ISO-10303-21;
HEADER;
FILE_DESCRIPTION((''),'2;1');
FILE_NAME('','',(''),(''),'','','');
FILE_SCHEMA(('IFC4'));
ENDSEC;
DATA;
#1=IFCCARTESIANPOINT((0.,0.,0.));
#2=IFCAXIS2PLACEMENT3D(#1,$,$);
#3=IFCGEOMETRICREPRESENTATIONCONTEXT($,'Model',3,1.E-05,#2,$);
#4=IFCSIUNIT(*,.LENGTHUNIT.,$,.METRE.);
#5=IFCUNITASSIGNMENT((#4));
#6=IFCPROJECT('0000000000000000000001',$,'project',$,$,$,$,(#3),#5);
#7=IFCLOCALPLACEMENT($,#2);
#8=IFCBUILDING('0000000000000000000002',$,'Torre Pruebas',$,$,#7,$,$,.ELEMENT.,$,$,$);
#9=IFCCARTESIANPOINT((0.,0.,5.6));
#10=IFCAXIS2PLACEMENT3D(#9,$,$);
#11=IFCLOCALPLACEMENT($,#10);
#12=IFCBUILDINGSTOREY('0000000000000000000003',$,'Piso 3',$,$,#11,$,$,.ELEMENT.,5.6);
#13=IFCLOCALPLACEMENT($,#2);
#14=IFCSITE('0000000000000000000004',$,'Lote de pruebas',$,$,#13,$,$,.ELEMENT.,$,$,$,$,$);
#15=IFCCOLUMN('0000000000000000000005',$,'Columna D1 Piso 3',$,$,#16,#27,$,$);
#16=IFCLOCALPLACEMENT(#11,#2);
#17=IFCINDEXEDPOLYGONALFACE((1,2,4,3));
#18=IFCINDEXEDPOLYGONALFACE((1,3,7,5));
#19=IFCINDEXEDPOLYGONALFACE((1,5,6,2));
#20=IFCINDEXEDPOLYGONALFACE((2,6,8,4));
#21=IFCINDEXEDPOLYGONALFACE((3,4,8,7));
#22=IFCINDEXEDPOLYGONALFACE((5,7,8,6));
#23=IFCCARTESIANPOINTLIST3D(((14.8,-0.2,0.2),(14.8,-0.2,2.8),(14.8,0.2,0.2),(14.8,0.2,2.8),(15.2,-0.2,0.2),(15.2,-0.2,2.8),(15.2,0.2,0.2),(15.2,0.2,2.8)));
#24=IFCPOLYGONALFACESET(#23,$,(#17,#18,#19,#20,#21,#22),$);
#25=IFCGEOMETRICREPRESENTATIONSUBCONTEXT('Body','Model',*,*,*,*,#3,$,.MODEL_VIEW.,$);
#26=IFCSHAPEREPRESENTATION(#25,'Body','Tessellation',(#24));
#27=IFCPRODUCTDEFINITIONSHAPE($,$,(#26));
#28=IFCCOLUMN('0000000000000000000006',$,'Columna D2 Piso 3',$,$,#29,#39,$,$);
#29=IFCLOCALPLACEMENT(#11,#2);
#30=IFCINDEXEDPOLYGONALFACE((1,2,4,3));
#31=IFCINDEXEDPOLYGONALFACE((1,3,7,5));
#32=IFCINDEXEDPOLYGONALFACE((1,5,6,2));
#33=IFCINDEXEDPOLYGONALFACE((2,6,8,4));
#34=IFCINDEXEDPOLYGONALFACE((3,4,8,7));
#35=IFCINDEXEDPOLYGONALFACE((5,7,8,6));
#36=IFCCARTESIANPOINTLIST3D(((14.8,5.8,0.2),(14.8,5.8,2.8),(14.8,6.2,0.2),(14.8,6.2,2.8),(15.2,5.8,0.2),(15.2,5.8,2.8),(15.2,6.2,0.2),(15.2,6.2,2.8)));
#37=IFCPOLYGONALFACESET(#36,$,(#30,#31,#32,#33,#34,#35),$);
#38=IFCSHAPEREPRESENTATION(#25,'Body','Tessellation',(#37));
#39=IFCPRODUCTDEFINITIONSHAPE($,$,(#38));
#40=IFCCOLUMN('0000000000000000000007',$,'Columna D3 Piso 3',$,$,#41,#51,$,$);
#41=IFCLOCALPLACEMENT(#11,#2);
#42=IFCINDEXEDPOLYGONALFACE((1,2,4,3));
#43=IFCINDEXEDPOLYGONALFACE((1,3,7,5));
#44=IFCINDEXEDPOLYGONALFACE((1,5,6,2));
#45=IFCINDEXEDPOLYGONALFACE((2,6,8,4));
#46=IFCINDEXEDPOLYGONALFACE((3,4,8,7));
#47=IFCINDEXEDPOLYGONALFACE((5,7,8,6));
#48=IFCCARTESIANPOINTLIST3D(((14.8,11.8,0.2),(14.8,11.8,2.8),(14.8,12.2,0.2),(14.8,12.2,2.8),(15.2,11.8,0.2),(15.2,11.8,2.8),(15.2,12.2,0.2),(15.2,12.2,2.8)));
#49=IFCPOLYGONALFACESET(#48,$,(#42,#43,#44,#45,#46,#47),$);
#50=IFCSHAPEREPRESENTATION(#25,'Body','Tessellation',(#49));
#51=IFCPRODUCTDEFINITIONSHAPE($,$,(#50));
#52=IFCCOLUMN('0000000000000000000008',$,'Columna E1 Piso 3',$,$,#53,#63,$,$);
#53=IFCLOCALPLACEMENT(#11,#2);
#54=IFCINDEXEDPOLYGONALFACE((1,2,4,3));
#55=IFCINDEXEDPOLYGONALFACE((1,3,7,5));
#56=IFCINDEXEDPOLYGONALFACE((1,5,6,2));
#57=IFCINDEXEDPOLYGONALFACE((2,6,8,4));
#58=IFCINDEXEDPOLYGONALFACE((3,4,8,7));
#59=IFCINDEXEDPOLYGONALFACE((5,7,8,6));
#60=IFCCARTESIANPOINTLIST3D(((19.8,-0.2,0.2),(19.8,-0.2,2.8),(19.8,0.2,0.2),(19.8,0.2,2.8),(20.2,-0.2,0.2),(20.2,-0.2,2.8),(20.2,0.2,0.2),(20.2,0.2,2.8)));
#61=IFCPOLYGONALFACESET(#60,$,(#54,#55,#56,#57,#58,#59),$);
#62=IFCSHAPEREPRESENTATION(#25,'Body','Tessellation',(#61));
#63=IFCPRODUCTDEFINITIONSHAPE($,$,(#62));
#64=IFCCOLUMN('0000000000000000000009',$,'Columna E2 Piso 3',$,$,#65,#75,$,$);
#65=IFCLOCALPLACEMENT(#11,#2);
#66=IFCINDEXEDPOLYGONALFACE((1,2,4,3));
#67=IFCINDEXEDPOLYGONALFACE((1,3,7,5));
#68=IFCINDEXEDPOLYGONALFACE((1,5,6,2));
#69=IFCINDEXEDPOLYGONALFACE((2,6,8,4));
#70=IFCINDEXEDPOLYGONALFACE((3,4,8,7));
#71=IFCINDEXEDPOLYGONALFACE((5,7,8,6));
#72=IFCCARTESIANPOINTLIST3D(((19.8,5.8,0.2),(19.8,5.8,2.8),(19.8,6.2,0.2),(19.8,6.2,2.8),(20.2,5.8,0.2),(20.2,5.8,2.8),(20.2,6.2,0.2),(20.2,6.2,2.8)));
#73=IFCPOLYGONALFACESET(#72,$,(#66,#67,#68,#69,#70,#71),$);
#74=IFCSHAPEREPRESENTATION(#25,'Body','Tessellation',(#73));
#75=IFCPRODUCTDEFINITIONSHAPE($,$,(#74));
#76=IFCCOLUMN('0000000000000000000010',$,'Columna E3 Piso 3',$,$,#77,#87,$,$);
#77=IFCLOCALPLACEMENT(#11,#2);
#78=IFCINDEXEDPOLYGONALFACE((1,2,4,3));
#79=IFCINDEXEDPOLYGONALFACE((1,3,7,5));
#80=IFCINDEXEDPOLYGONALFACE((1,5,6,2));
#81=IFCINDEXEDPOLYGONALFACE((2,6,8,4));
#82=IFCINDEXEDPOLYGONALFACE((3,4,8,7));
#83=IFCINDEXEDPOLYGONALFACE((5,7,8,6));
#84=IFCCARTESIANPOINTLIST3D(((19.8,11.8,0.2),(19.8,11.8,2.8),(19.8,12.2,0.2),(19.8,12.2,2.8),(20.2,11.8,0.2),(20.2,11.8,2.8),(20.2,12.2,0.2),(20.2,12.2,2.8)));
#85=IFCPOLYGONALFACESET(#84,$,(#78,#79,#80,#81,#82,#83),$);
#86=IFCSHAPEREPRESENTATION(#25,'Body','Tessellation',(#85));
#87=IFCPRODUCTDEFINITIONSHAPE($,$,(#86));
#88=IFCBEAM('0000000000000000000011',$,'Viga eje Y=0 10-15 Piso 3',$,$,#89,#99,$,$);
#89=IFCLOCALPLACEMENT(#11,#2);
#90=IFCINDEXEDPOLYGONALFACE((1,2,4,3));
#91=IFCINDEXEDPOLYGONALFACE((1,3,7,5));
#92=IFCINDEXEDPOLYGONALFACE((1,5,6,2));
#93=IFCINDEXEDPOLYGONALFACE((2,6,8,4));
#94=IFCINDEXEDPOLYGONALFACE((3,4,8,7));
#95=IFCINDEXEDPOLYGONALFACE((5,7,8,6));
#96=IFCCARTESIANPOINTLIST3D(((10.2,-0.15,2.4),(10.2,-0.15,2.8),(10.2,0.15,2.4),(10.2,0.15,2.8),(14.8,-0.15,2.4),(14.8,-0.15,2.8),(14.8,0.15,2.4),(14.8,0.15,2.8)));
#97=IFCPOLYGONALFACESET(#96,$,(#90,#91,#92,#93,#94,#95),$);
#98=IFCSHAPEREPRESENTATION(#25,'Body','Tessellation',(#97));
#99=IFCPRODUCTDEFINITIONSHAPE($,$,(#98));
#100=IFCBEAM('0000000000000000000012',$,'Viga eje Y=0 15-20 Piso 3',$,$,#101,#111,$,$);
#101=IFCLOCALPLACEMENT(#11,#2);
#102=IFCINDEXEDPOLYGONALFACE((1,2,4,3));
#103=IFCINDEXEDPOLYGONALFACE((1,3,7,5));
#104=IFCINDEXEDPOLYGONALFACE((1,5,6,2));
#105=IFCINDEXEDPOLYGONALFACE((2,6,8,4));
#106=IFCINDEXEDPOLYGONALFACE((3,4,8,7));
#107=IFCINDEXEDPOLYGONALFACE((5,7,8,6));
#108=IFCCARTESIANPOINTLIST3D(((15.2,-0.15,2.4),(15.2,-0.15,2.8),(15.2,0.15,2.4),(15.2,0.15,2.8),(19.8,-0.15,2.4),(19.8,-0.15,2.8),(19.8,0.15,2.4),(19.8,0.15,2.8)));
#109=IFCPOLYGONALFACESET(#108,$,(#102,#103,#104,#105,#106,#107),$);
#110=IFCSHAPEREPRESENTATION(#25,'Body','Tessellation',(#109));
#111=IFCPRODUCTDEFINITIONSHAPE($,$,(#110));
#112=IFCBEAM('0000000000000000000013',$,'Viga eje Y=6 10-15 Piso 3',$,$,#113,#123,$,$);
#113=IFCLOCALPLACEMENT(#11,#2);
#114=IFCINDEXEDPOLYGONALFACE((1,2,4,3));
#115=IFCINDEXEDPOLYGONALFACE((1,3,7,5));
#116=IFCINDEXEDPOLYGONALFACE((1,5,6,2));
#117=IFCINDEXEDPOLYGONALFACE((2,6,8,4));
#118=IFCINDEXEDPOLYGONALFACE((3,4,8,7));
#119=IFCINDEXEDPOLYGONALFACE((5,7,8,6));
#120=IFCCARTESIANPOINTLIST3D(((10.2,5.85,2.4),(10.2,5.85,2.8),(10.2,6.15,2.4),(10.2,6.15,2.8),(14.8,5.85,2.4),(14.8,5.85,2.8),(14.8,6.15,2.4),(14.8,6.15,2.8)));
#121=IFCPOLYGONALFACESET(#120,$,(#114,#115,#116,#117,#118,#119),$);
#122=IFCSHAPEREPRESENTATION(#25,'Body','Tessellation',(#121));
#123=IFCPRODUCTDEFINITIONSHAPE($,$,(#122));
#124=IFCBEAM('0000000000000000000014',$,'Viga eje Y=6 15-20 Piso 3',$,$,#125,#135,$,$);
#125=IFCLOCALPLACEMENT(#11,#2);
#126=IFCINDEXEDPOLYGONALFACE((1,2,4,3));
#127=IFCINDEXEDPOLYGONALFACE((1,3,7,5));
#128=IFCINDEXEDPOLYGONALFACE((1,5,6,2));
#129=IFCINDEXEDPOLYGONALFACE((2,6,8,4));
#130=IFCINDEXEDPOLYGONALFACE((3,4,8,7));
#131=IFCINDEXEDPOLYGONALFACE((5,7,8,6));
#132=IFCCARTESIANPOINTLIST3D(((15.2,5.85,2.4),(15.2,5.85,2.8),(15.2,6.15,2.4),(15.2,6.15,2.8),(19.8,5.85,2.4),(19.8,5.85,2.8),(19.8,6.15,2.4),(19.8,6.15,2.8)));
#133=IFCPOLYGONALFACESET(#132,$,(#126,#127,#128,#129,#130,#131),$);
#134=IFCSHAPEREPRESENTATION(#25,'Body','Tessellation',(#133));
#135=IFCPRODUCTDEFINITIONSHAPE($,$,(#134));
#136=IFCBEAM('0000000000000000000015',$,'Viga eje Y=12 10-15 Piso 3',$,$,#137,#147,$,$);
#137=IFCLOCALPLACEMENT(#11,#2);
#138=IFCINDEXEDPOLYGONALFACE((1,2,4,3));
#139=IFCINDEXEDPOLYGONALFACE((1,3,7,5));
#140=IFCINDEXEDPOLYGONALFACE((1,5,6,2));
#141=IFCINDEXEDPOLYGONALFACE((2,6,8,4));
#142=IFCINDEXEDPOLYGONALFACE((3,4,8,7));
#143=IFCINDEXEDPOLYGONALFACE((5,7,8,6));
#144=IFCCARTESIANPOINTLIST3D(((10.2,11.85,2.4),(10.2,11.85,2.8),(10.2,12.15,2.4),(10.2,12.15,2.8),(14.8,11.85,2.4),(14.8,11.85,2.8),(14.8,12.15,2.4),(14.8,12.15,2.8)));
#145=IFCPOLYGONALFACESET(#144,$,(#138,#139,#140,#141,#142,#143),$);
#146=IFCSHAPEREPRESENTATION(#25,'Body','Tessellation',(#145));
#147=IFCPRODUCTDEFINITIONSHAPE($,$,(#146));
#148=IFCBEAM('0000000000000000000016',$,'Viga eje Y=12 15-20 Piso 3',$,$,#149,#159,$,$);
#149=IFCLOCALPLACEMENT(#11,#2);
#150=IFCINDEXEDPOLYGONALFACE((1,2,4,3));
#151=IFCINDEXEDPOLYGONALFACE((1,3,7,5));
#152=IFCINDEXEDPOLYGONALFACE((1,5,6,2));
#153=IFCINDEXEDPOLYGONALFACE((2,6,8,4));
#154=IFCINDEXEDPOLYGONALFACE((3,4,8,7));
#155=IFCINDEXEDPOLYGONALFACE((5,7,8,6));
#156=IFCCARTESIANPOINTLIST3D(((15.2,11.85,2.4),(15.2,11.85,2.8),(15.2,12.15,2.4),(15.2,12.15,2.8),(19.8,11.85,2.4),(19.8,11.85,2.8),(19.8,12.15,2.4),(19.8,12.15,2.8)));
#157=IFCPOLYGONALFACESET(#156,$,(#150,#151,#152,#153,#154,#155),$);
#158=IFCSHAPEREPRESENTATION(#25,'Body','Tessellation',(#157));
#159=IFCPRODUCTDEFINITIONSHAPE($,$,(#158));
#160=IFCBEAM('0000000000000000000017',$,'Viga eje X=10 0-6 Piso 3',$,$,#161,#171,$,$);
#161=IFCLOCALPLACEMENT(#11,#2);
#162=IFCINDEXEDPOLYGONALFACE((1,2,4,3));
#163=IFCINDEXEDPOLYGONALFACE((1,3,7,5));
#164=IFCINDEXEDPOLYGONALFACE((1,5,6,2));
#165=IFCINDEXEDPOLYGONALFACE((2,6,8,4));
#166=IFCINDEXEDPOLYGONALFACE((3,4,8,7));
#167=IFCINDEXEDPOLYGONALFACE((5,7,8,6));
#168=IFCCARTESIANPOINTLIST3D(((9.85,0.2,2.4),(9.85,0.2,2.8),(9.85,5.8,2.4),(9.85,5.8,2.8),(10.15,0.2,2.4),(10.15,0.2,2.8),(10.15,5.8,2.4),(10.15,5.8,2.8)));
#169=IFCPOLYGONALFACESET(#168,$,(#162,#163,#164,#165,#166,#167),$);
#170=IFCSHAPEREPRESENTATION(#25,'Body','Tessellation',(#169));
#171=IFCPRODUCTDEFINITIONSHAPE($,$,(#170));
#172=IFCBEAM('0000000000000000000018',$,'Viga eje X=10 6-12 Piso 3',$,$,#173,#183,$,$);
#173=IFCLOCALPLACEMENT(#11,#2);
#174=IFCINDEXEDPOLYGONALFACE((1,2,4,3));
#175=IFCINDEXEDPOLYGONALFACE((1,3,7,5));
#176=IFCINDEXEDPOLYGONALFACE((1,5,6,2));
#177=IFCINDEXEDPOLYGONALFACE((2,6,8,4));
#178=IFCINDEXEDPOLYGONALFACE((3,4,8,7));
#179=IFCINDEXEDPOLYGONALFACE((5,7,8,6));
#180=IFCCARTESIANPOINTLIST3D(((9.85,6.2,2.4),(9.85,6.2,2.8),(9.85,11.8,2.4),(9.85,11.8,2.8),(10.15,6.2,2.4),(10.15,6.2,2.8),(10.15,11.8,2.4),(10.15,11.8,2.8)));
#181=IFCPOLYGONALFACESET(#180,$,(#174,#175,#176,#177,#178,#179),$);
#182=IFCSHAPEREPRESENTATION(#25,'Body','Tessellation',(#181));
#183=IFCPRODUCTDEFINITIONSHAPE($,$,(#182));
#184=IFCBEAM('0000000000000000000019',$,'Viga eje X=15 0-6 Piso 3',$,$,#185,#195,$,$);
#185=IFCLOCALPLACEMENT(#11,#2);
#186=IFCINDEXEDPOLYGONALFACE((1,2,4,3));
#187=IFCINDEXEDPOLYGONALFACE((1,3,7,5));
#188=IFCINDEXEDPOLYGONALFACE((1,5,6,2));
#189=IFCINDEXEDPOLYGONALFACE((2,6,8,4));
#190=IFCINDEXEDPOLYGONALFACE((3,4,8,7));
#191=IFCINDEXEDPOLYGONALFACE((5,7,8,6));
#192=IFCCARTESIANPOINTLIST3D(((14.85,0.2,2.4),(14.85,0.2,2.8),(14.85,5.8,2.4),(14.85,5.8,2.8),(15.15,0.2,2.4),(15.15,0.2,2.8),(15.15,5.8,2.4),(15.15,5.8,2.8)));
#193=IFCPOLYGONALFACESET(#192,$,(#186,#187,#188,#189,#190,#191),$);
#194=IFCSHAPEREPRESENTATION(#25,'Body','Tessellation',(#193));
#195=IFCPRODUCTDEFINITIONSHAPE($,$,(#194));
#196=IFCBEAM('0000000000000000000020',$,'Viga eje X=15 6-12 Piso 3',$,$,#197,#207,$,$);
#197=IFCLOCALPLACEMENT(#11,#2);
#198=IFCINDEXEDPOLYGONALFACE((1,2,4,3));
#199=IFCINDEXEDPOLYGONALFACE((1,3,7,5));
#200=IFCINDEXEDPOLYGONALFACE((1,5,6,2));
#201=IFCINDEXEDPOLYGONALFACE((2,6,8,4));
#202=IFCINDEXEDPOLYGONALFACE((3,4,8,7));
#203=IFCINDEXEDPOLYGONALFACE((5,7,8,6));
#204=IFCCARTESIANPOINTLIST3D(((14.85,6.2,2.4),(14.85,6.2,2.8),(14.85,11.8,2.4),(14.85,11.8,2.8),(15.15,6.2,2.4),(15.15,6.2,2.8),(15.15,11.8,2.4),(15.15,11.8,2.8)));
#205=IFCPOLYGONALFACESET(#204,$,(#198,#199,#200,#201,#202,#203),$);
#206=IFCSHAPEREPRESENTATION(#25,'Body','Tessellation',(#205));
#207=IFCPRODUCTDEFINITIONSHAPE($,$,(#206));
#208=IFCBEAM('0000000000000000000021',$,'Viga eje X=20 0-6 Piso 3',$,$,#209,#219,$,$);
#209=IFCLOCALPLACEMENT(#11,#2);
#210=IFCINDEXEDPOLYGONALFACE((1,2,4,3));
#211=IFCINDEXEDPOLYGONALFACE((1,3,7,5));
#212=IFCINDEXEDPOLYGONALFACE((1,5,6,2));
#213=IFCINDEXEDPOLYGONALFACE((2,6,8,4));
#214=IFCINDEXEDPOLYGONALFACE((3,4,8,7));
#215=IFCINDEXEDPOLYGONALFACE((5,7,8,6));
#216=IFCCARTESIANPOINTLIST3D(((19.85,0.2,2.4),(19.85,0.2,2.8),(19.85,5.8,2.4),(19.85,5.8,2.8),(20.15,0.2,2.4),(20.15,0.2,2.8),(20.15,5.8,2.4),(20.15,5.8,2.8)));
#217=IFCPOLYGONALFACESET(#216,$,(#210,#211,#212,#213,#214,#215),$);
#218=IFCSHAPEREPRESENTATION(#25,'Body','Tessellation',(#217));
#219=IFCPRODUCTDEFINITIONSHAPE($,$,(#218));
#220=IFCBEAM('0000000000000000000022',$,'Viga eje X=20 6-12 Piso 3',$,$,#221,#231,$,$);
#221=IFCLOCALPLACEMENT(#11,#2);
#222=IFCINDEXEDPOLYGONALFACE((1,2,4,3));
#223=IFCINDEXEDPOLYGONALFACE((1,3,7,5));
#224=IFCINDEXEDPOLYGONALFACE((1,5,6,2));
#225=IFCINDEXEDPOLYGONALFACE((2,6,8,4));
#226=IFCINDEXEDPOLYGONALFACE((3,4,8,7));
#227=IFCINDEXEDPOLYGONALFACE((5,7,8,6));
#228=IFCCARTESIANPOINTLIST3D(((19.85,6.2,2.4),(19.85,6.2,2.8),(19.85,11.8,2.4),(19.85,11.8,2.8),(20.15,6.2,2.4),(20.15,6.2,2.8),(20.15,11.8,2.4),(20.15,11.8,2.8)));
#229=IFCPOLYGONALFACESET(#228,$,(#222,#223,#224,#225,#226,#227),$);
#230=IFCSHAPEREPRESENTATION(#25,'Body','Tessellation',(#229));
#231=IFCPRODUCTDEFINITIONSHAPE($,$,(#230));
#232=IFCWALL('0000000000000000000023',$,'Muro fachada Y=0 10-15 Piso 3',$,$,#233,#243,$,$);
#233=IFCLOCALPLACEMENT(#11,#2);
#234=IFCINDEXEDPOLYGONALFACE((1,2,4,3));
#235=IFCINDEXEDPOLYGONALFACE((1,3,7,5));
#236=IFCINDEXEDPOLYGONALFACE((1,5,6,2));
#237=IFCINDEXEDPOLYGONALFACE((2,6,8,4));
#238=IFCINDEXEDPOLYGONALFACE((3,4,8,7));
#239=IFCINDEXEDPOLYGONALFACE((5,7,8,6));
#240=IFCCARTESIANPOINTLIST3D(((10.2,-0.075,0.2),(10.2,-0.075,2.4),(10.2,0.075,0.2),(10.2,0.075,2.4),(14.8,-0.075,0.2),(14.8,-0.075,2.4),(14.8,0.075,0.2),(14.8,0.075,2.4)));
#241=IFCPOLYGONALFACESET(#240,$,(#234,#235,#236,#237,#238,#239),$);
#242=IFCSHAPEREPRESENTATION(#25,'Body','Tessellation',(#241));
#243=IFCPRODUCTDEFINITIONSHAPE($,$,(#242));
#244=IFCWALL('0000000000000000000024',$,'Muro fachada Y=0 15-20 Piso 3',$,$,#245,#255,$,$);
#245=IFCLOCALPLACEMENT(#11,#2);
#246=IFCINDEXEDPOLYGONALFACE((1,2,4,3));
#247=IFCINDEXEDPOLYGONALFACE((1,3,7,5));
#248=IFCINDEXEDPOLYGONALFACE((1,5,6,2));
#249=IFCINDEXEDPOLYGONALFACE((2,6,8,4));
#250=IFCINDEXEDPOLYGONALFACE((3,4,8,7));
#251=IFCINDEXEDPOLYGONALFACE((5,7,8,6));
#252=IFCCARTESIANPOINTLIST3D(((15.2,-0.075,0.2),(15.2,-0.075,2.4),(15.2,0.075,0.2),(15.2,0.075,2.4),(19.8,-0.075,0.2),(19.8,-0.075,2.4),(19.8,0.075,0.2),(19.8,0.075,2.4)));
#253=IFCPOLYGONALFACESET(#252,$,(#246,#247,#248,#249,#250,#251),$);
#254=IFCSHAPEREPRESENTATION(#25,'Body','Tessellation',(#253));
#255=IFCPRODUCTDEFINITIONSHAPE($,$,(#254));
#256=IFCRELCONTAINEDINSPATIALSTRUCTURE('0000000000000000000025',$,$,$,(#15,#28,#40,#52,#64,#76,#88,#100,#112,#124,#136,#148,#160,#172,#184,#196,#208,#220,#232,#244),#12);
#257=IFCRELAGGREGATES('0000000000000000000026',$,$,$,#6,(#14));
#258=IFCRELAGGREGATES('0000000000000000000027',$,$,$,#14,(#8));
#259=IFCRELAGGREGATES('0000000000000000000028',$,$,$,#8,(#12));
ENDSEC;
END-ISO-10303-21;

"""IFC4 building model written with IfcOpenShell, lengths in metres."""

from ifc_helpers import new_model, si_unit, frame, origin, origin_2d, place, context, subcontext, project, spatial, rectangle, extrude, element, save


model = new_model("IFC4")

# Units and contexts
model_context = context("Model", 3, precision=1e-05, world=origin())
body_context = subcontext(model_context, "Body", "Model", "MODEL_VIEW")
ifc_project = project(units=[si_unit("LENGTHUNIT", "METRE")], contexts=[model_context])

# Site, building, storey
site_placement = place(None, origin())
site = spatial("IfcSite", under=ifc_project, at=site_placement, Name="Lote de pruebas", CompositionType="ELEMENT")
building_placement = place(None, origin())
building = spatial("IfcBuilding", under=site, at=building_placement, Name="Torre Pruebas", CompositionType="ELEMENT")
storey_placement = place(None, frame((0.0, 0.0, 5.6)))
storey = spatial("IfcBuildingStorey", under=building, at=storey_placement, Name="Piso 3", CompositionType="ELEMENT", Elevation=5.6)

# Columns
for number, where, name in (
    (1, (15.0, 0.0, 5.8), "Columna D1 Piso 3"),
    (2, (15.0, 6.0, 5.8), "Columna D2 Piso 3"),
    (3, (15.0, 12.0, 5.8), "Columna D3 Piso 3"),
    (4, (20.0, 0.0, 5.8), "Columna E1 Piso 3"),
    (5, (20.0, 6.0, 5.8), "Columna E2 Piso 3"),
    (6, (20.0, 12.0, 5.8), "Columna E3 Piso 3"),
):
    element("IfcColumn", number, at=place(None, frame(where)), inside=storey, Name=name, context=body_context, shape_type="SweptSolid", body=[
        extrude(rectangle(XDim=0.4, YDim=0.4, at=origin_2d()), origin(), (0.0, 0.0, 1.0), 2.6),
    ])

# Beams
for number, where, name in (
    (7, (12.5, 0.0, 8.0), "Viga eje Y=0 10-15 Piso 3"),
    (8, (17.5, 0.0, 8.0), "Viga eje Y=0 15-20 Piso 3"),
    (9, (12.5, 6.0, 8.0), "Viga eje Y=6 10-15 Piso 3"),
    (10, (17.5, 6.0, 8.0), "Viga eje Y=6 15-20 Piso 3"),
    (11, (12.5, 12.0, 8.0), "Viga eje Y=12 10-15 Piso 3"),
    (12, (17.5, 12.0, 8.0), "Viga eje Y=12 15-20 Piso 3"),
):
    element("IfcBeam", number, at=place(None, frame(where)), inside=storey, Name=name, context=body_context, shape_type="SweptSolid", body=[
        extrude(rectangle(XDim=4.6, YDim=0.3, at=origin_2d()), origin(), (0.0, 0.0, 1.0), 0.4),
    ])
for number, where, name in (
    (13, (10.0, 3.0, 8.0), "Viga eje X=10 0-6 Piso 3"),
    (14, (10.0, 9.0, 8.0), "Viga eje X=10 6-12 Piso 3"),
    (15, (15.0, 3.0, 8.0), "Viga eje X=15 0-6 Piso 3"),
    (16, (15.0, 9.0, 8.0), "Viga eje X=15 6-12 Piso 3"),
    (17, (20.0, 3.0, 8.0), "Viga eje X=20 0-6 Piso 3"),
    (18, (20.0, 9.0, 8.0), "Viga eje X=20 6-12 Piso 3"),
):
    element("IfcBeam", number, at=place(None, frame(where)), inside=storey, Name=name, context=body_context, shape_type="SweptSolid", body=[
        extrude(rectangle(XDim=0.3, YDim=5.6, at=origin_2d()), origin(), (0.0, 0.0, 1.0), 0.4),
    ])

# Walls
for number, where, name in (
    (19, (12.5, 0.0, 5.8), "Muro fachada Y=0 10-15 Piso 3"),
    (20, (17.5, 0.0, 5.8), "Muro fachada Y=0 15-20 Piso 3"),
):
    element("IfcWall", number, at=place(None, frame(where)), inside=storey, Name=name, context=body_context, shape_type="SweptSolid", body=[
        extrude(rectangle(XDim=4.6, YDim=0.15, at=origin_2d()), origin(), (0.0, 0.0, 1.0), 2.2),
    ])

save(model, "model.ifc")
